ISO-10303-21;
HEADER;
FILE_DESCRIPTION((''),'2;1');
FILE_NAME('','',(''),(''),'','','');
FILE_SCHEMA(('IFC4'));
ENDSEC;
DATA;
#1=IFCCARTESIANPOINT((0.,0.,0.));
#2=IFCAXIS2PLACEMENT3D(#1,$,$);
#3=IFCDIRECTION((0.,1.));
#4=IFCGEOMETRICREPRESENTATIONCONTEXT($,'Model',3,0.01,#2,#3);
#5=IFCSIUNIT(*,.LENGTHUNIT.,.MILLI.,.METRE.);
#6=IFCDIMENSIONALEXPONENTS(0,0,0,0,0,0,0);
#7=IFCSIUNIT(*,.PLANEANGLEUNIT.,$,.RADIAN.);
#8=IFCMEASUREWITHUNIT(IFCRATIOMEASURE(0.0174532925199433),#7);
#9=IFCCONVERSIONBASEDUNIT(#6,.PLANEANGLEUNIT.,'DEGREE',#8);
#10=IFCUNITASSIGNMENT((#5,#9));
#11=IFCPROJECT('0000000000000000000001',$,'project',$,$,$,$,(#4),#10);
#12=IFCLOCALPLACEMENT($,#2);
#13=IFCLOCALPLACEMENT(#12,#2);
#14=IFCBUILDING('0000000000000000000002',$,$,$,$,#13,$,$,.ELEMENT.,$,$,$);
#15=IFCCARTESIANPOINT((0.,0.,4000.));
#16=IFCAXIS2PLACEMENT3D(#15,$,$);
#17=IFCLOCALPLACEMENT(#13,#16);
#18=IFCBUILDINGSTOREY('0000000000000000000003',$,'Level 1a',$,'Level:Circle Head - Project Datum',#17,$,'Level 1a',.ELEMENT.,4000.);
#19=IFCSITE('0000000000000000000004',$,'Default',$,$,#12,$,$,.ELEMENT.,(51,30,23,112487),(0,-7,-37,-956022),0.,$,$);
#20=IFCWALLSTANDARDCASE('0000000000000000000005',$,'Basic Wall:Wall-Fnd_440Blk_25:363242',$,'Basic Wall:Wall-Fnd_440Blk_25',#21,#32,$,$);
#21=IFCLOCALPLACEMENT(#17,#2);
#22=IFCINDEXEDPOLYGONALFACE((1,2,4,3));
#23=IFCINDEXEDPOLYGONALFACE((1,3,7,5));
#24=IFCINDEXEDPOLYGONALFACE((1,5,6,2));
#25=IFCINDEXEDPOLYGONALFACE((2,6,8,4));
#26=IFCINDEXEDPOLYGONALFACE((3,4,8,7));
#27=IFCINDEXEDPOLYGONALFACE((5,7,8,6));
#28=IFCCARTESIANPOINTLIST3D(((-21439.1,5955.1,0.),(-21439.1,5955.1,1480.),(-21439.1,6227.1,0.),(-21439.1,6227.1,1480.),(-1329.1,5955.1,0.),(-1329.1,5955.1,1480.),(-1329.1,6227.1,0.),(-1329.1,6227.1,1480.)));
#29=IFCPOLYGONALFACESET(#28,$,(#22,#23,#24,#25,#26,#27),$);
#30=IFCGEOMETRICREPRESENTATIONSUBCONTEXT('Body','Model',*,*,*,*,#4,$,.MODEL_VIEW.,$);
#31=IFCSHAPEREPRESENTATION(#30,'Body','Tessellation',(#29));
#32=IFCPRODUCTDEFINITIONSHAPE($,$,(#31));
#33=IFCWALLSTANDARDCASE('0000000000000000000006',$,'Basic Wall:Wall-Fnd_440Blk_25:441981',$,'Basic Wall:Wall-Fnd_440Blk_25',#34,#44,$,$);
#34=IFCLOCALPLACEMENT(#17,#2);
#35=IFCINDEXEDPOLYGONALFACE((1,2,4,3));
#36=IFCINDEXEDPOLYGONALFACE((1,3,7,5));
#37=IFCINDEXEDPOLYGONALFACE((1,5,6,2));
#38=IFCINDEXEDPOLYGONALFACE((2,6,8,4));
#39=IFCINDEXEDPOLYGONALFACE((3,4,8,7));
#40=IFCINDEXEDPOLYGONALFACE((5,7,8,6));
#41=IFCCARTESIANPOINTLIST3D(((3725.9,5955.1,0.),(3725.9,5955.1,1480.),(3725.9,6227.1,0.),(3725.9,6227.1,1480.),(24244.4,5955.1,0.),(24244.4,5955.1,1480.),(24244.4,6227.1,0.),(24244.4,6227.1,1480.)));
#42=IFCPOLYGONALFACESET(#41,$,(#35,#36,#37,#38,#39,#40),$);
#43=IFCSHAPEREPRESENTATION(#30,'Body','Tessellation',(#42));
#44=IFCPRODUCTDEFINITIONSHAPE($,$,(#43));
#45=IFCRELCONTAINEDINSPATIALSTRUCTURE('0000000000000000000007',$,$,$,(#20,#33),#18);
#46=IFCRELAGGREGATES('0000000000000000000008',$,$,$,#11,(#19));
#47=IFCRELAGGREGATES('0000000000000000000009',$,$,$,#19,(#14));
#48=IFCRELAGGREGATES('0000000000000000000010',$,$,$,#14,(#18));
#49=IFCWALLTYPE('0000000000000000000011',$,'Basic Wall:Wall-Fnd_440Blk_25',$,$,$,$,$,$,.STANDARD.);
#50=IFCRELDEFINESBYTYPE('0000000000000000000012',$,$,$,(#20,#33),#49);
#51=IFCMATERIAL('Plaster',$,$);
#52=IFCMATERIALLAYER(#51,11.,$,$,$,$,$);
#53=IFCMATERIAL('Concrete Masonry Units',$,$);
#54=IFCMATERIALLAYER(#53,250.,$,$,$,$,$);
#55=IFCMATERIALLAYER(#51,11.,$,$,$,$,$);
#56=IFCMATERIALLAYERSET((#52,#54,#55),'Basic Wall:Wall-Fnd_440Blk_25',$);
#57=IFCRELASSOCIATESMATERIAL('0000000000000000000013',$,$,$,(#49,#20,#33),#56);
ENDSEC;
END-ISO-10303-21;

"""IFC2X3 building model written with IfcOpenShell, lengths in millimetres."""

from ifc_helpers import new_model, entity, si_unit, converted_unit, direction, frame, frame_2d, origin, place, context, subcontext, project, spatial, rectangle, extrude, material, layer, layer_set, layer_usage, type_object, element, save


model = new_model("IFC2X3")

# Units and contexts
model_context = context("Model", 3, precision=0.01, world=origin(), true_north=direction((0.0, 1.0)))
body_context = subcontext(model_context, "Body", "Model", "MODEL_VIEW")
ifc_project = project(units=[si_unit("LENGTHUNIT", "METRE", prefix="MILLI"), converted_unit("PLANEANGLEUNIT", "DEGREE", entity("IfcRatioMeasure", 0.0174532925199433), si_unit("PLANEANGLEUNIT", "RADIAN"), dimensions=[0, 0, 0, 0, 0, 0, 0])], contexts=[model_context])

# Site, building, storey
site_placement = place(None, origin())
site = spatial("IfcSite", under=ifc_project, at=site_placement, Name="Default", CompositionType="ELEMENT", RefLatitude=(51, 30, 23, 112487), RefLongitude=(0, -7, -37, -956022), RefElevation=0.0)
building_placement = place(site_placement, origin())
building = spatial("IfcBuilding", under=site, at=building_placement, CompositionType="ELEMENT")
storey_placement = place(building_placement, frame((0.0, 0.0, 4000.0)))
storey = spatial("IfcBuildingStorey", under=building, at=storey_placement, Name="Level 1a", ObjectType="Level:Circle Head - Project Datum", LongName="Level 1a", CompositionType="ELEMENT", Elevation=4000.0)

# Walls
ifc_material_1 = material(Name="Plaster")
ifc_layer_1 = layer(ifc_material_1, 11.0)
ifc_material_2 = material(Name="Concrete Masonry Units")
ifc_layer_2 = layer(ifc_material_2, 250.0)
ifc_layer_3 = layer(ifc_material_1, 11.0)
ifc_layer_set = layer_set([ifc_layer_1, ifc_layer_2, ifc_layer_3], Name="Basic Wall:Wall-Fnd_440Blk_25")
ifc_layer_usage_1 = layer_usage(ifc_layer_set, "AXIS2", "NEGATIVE", 136.0)
wall_type = type_object("IfcWallType", Name="Basic Wall:Wall-Fnd_440Blk_25", PredefinedType="STANDARD", material=ifc_layer_set)
wall_1_placement = place(storey_placement, frame((-1329.1, 6091.1, 0.0), z_axis=(0.0, 0.0, 1.0), x_axis=(-1.0, 0.0, 0.0)))
element("IfcWallStandardCase", 1, at=wall_1_placement, inside=storey, type_object=wall_type, material=ifc_layer_usage_1, Name="Basic Wall:Wall-Fnd_440Blk_25:363242", ObjectType="Basic Wall:Wall-Fnd_440Blk_25", context=body_context, shape_type="SweptSolid", body=[
    extrude(rectangle(XDim=20110.0, YDim=272.0, at=frame_2d((10055.0, 0.0), x_axis=(-1.0, 0.0))), origin(), (0.0, 0.0, 1.0), 1480.0),
])
ifc_layer_usage_2 = layer_usage(ifc_layer_set, "AXIS2", "NEGATIVE", 136.0)
wall_2_placement = place(storey_placement, frame((24244.4, 6091.1, 0.0), z_axis=(0.0, 0.0, 1.0), x_axis=(-1.0, 0.0, 0.0)))
element("IfcWallStandardCase", 2, at=wall_2_placement, inside=storey, type_object=wall_type, material=ifc_layer_usage_2, Name="Basic Wall:Wall-Fnd_440Blk_25:441981", ObjectType="Basic Wall:Wall-Fnd_440Blk_25", context=body_context, shape_type="SweptSolid", body=[
    extrude(rectangle(XDim=20518.5, YDim=272.0, at=frame_2d((10259.3, 0.0), x_axis=(-1.0, 0.0))), origin(), (0.0, 0.0, 1.0), 1480.0),
])

save(model, "model.ifc")
